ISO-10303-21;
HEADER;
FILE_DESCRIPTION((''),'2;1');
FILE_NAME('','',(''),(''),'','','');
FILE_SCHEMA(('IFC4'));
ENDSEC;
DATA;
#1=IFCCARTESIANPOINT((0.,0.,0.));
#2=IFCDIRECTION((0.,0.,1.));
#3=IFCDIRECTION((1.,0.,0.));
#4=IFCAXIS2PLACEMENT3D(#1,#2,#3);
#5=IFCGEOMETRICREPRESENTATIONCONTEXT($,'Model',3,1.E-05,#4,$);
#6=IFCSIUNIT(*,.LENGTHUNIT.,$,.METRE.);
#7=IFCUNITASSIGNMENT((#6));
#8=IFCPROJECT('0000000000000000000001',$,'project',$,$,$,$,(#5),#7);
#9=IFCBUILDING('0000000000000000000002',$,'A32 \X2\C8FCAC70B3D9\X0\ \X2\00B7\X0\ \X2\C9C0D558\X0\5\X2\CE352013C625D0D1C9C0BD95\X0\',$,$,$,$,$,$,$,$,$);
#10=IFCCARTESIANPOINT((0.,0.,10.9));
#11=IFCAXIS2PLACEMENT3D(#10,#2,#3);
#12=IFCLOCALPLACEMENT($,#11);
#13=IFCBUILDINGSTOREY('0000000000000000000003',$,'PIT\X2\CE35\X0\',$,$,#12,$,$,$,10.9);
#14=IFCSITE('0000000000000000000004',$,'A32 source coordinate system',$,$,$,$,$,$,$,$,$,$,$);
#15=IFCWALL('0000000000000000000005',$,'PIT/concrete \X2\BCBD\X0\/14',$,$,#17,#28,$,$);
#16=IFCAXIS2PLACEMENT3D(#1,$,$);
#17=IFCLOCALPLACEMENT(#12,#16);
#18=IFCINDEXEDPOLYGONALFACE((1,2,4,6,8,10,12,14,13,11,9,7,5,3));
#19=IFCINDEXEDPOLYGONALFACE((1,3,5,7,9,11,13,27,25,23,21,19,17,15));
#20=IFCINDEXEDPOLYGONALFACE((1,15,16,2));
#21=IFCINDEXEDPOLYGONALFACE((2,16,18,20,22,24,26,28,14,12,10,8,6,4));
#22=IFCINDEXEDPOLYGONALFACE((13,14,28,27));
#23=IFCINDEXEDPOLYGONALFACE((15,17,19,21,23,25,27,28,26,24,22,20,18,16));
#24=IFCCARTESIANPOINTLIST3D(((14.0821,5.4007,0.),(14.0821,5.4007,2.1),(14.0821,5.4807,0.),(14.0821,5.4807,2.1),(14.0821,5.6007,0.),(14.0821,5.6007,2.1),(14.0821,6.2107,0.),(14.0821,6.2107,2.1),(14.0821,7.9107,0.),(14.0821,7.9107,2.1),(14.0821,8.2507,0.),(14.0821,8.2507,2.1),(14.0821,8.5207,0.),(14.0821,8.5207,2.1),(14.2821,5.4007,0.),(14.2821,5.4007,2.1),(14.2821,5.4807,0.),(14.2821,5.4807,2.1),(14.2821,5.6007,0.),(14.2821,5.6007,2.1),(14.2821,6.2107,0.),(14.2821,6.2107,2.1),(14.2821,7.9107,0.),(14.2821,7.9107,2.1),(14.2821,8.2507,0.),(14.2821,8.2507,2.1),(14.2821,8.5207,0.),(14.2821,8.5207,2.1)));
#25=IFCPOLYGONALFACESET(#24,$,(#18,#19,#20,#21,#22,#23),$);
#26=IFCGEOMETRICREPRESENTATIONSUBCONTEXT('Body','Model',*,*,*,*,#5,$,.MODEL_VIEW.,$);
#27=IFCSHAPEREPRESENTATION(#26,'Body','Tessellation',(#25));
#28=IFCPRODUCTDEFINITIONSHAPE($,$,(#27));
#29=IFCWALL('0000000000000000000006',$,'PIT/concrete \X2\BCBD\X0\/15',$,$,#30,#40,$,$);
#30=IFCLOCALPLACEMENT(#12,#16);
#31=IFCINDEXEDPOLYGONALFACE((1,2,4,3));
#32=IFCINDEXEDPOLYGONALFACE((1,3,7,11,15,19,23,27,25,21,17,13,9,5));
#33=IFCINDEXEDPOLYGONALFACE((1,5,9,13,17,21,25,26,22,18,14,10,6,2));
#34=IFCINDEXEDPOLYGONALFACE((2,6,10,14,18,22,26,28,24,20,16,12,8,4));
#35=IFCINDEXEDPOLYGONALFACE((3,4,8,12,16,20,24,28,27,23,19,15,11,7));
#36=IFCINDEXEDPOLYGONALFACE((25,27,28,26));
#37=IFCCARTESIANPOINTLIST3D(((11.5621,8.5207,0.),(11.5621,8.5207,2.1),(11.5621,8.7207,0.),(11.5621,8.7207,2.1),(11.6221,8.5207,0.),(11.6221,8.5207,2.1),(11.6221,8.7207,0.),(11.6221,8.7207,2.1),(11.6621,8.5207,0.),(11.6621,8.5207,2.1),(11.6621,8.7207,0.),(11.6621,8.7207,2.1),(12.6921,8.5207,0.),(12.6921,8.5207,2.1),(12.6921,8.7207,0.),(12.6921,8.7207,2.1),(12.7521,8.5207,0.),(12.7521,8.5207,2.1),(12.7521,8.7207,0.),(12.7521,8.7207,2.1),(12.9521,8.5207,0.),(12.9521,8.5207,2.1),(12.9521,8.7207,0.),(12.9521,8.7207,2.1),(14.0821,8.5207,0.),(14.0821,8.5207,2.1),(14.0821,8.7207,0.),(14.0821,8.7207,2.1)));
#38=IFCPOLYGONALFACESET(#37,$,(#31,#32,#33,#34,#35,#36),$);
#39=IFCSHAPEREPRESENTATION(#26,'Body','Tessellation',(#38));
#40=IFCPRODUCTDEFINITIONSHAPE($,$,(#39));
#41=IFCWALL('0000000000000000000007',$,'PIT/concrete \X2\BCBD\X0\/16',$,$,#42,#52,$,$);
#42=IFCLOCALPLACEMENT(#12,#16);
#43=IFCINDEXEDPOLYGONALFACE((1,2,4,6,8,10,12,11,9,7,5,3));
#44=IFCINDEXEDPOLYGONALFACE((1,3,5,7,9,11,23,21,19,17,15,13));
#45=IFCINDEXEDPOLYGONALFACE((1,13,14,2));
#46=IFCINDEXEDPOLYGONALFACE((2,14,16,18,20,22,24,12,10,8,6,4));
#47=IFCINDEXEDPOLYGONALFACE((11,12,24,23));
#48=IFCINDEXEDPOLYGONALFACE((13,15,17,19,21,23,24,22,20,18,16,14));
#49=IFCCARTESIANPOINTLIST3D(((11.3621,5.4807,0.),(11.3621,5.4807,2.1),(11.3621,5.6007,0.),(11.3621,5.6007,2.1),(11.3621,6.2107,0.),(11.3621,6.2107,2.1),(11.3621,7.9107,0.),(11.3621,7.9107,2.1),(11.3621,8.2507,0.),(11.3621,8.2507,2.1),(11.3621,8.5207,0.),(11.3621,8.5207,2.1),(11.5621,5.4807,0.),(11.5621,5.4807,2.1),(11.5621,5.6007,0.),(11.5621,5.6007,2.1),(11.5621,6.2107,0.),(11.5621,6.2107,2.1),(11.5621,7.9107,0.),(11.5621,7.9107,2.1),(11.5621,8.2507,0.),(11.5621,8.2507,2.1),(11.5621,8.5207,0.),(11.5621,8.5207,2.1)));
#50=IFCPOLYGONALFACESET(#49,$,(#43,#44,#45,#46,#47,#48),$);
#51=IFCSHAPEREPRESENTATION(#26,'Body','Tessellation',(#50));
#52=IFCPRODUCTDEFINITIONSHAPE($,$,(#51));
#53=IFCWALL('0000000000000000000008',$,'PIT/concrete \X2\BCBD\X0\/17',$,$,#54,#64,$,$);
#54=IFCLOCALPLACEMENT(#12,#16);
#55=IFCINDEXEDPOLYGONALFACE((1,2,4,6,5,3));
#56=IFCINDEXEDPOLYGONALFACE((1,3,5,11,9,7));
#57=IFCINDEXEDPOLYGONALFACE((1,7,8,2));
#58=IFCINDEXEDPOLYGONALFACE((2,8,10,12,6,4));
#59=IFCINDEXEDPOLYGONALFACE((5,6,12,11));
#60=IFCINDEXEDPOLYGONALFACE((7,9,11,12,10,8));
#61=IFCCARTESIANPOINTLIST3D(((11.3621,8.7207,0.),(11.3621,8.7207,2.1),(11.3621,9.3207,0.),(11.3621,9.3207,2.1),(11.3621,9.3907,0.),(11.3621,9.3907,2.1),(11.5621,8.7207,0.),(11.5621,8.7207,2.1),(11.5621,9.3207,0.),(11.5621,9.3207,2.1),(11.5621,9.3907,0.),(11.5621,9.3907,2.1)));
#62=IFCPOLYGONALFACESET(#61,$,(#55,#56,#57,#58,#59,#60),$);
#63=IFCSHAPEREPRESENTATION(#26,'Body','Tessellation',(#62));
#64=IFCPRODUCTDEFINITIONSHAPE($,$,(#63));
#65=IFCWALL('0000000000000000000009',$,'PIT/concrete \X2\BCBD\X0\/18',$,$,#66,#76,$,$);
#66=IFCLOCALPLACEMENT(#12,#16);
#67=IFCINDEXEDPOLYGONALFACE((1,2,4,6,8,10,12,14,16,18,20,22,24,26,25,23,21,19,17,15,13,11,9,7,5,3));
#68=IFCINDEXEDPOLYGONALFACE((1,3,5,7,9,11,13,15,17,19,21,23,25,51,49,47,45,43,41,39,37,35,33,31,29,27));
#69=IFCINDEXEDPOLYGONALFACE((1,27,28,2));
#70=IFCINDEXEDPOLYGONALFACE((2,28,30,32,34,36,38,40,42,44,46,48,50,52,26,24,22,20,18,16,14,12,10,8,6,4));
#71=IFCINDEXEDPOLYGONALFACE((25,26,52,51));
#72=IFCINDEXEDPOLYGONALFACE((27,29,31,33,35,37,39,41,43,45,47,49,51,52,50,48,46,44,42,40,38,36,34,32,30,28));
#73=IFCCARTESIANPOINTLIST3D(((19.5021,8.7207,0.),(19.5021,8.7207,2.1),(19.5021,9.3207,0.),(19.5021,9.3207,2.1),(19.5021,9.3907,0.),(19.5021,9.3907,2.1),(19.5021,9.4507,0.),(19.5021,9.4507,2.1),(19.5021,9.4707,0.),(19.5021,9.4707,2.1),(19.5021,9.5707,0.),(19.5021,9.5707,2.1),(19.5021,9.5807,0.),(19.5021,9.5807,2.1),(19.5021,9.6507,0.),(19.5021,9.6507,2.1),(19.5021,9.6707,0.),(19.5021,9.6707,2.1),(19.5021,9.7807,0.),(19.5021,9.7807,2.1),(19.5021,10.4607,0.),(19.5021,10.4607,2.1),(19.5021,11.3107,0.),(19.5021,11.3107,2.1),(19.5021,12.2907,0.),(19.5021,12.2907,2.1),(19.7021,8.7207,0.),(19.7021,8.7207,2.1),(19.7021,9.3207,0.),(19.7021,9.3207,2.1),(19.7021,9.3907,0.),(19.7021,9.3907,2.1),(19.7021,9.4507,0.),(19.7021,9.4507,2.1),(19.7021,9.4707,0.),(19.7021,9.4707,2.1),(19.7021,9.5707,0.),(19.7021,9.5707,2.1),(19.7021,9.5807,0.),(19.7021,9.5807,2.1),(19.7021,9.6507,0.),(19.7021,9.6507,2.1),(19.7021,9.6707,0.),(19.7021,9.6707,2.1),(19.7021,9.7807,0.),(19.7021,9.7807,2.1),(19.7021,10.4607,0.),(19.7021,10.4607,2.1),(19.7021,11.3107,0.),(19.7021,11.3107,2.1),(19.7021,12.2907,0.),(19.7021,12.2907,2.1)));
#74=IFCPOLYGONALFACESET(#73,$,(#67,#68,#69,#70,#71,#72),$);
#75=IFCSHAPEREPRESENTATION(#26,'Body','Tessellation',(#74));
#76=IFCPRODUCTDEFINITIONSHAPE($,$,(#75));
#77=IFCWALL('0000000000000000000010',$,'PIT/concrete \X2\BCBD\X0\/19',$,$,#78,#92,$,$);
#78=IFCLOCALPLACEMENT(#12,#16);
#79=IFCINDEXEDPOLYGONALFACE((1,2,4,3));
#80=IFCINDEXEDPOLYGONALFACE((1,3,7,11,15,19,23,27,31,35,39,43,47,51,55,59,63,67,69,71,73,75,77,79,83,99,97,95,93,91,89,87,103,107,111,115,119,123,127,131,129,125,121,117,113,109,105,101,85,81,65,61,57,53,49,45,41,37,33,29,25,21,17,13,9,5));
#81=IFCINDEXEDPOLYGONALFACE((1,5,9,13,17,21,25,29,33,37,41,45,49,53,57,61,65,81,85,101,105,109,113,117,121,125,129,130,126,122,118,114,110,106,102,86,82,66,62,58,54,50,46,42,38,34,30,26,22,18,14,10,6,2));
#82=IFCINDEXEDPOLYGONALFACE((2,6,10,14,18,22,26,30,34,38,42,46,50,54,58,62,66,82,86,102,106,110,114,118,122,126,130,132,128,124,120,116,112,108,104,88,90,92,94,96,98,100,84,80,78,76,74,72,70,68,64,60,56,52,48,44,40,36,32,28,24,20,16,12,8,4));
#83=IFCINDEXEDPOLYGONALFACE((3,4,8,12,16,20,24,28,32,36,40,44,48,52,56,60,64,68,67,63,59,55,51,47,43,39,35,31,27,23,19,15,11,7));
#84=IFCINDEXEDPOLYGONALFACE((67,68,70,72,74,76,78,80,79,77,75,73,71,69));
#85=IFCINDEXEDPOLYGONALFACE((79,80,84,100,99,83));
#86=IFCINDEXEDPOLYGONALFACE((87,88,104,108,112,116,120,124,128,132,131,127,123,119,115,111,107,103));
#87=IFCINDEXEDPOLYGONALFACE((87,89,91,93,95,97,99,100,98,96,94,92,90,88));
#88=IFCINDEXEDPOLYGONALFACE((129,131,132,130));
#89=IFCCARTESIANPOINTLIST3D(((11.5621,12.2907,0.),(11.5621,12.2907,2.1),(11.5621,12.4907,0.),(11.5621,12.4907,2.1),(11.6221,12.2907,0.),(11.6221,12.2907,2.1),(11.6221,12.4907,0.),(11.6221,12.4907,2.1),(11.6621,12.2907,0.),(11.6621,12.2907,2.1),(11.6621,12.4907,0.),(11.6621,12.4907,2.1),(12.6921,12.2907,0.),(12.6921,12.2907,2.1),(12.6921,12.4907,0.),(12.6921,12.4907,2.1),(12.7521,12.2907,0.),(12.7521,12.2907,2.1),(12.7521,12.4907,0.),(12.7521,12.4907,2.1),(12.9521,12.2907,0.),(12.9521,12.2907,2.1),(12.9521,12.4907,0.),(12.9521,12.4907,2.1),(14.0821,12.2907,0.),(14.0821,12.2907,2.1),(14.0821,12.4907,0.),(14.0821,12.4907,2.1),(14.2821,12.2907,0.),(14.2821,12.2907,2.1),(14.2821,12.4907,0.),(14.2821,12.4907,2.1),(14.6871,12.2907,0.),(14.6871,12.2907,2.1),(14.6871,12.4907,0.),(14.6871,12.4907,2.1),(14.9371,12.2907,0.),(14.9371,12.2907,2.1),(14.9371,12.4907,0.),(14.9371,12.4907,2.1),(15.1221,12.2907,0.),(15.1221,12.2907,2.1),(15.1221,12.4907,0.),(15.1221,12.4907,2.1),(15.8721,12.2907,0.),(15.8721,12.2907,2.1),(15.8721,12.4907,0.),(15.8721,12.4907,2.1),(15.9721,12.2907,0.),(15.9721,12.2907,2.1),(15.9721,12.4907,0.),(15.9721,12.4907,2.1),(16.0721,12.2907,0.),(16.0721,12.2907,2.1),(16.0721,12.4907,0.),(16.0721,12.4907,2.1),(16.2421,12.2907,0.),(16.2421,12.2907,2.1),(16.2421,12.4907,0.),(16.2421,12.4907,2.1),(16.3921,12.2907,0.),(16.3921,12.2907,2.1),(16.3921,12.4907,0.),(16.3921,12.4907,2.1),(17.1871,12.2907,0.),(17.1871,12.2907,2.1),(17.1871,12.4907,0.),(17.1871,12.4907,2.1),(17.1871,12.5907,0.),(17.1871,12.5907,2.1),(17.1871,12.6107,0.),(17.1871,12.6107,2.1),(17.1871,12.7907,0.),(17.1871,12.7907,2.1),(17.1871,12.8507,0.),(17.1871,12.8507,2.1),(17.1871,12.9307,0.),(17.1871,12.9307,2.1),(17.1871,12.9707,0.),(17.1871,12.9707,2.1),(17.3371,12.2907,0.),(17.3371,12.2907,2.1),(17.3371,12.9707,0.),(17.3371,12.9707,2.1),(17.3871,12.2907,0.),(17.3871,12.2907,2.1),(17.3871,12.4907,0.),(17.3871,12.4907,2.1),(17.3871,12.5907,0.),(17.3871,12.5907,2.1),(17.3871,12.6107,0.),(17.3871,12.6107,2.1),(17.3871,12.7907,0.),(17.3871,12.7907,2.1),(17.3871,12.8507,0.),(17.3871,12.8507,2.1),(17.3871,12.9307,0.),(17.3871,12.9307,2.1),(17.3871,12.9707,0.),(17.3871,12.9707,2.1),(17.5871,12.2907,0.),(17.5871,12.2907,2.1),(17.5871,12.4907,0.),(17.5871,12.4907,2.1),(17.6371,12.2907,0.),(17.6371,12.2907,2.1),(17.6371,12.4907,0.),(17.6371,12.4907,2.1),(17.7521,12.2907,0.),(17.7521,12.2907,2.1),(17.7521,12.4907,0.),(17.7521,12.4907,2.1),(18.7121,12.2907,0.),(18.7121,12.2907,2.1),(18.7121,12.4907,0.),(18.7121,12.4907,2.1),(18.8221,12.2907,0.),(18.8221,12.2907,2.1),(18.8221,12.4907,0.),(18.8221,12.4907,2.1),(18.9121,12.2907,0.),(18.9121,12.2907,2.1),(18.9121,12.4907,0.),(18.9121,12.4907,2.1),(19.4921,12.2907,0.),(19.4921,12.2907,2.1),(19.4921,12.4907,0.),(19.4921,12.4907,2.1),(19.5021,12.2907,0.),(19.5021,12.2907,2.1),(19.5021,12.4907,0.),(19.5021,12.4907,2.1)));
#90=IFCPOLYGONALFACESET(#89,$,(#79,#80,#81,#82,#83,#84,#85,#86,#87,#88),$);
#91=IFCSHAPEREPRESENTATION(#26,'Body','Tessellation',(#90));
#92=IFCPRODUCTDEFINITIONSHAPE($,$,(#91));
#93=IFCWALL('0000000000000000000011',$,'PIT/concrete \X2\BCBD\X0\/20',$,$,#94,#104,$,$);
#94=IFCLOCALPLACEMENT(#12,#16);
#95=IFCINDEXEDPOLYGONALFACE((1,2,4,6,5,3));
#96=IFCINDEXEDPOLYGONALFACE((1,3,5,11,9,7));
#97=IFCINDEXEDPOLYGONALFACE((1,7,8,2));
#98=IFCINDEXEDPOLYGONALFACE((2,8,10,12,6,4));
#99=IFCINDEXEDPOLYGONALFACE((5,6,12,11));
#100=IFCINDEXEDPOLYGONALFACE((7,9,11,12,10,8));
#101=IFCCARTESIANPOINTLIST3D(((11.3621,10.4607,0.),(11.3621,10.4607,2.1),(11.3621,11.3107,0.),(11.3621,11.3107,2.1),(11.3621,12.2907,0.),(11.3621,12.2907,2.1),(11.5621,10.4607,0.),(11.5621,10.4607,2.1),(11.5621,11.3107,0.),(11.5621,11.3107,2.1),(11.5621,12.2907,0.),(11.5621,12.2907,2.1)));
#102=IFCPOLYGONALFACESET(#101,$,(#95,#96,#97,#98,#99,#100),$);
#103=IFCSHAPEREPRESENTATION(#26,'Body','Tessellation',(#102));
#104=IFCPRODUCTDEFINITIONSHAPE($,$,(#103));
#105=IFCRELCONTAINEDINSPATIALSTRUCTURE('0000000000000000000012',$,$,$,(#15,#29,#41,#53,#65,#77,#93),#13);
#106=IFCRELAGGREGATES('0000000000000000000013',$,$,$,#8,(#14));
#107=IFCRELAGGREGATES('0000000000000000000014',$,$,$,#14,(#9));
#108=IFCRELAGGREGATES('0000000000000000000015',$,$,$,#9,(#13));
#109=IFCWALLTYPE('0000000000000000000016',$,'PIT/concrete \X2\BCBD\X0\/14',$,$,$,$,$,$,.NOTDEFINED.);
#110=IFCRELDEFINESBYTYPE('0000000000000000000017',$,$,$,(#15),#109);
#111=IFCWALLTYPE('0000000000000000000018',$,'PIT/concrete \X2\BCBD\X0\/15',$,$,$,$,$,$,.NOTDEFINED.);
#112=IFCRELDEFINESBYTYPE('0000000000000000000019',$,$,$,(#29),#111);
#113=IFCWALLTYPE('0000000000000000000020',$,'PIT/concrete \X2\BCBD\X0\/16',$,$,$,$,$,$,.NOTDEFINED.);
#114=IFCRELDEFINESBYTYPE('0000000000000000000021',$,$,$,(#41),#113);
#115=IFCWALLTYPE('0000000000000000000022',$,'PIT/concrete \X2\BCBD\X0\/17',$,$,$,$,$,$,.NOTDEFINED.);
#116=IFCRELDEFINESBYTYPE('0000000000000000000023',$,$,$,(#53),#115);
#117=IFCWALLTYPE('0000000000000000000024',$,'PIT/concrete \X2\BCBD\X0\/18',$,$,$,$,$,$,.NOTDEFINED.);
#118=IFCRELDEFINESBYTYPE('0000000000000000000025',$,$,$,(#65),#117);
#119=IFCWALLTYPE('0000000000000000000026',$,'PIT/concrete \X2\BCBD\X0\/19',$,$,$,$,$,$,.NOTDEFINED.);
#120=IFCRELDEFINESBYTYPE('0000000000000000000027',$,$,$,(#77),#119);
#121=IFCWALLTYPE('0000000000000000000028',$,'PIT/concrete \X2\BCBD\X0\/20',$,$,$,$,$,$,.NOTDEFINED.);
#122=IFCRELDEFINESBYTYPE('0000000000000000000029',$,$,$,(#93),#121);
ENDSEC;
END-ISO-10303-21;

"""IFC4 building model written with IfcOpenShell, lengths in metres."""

from ifc_helpers import new_model, si_unit, frame, origin, origin_with_axes, place, context, subcontext, project, spatial, polyline, outline, extrude, source, transform, mapped, type_object, type_shapes, element, save


model = new_model("IFC4")

# Units and contexts
model_context = context("Model", 3, precision=1e-05, world=origin_with_axes())
body_context = subcontext(model_context, "Body", "Model", "MODEL_VIEW")
ifc_project = project(units=[si_unit("LENGTHUNIT", "METRE")], contexts=[model_context])

# Site, building, storey
site = spatial("IfcSite", under=ifc_project, Name="A32 source coordinate system")
building = spatial("IfcBuilding", under=site, Name="A32 주거동 · 지하5층–옥탑지붕")
storey_placement = place(None, frame((0.0, 0.0, 10.9), z_axis=(0.0, 0.0, 1.0), x_axis=(1.0, 0.0, 0.0)))
storey = spatial("IfcBuildingStorey", under=building, at=storey_placement, Name="PIT층", Elevation=10.9)

# Walls
wall_type_1 = type_object("IfcWallType", Name="PIT/concrete 벽/14", PredefinedType="NOTDEFINED")
shared_shape_1 = source(origin(), body_context, "Body", "SweptSolid", [
    extrude(outline(polyline([(14.2821, 6.2107), (14.2821, 5.6007), (14.2821, 5.4807), (14.2821, 5.4007), (14.0821, 5.4007), (14.0821, 5.4807), (14.0821, 5.6007), (14.0821, 6.2107), (14.0821, 7.9107), (14.0821, 8.2507), (14.0821, 8.5207), (14.2821, 8.5207), (14.2821, 8.2507), (14.2821, 7.9107), (14.2821, 6.2107)])), origin(), (0.0, 0.0, 1.0), 2.1),
])
type_shapes(wall_type_1, [shared_shape_1])
wall_1_placement = place(storey_placement, origin_with_axes())
element("IfcWall", 1, at=wall_1_placement, inside=storey, type_object=wall_type_1, Name="PIT/concrete 벽/14", context=body_context, shape_type="MappedRepresentation", body=[
    mapped(shared_shape_1, transform((0.0, 0.0, 0.0), scale=1.0)),
])
wall_type_2 = type_object("IfcWallType", Name="PIT/concrete 벽/15", PredefinedType="NOTDEFINED")
shared_shape_2 = source(origin(), body_context, "Body", "SweptSolid", [
    extrude(outline(polyline([(12.6921, 8.5207), (11.6621, 8.5207), (11.6221, 8.5207), (11.5621, 8.5207), (11.5621, 8.7207), (11.6221, 8.7207), (11.6621, 8.7207), (12.6921, 8.7207), (12.7521, 8.7207), (12.9521, 8.7207), (14.0821, 8.7207), (14.0821, 8.5207), (12.9521, 8.5207), (12.7521, 8.5207), (12.6921, 8.5207)])), origin(), (0.0, 0.0, 1.0), 2.1),
])
type_shapes(wall_type_2, [shared_shape_2])
wall_2_placement = place(storey_placement, origin_with_axes())
element("IfcWall", 2, at=wall_2_placement, inside=storey, type_object=wall_type_2, Name="PIT/concrete 벽/15", context=body_context, shape_type="MappedRepresentation", body=[
    mapped(shared_shape_2, transform((0.0, 0.0, 0.0), scale=1.0)),
])
wall_type_3 = type_object("IfcWallType", Name="PIT/concrete 벽/16", PredefinedType="NOTDEFINED")
shared_shape_3 = source(origin(), body_context, "Body", "SweptSolid", [
    extrude(outline(polyline([(11.5621, 6.2107), (11.5621, 5.6007), (11.5621, 5.4807), (11.3621, 5.4807), (11.3621, 5.6007), (11.3621, 6.2107), (11.3621, 7.9107), (11.3621, 8.2507), (11.3621, 8.5207), (11.5621, 8.5207), (11.5621, 8.2507), (11.5621, 7.9107), (11.5621, 6.2107)])), origin(), (0.0, 0.0, 1.0), 2.1),
])
type_shapes(wall_type_3, [shared_shape_3])
wall_3_placement = place(storey_placement, origin_with_axes())
element("IfcWall", 3, at=wall_3_placement, inside=storey, type_object=wall_type_3, Name="PIT/concrete 벽/16", context=body_context, shape_type="MappedRepresentation", body=[
    mapped(shared_shape_3, transform((0.0, 0.0, 0.0), scale=1.0)),
])
wall_type_4 = type_object("IfcWallType", Name="PIT/concrete 벽/17", PredefinedType="NOTDEFINED")
shared_shape_4 = source(origin(), body_context, "Body", "SweptSolid", [
    extrude(outline(polyline([(11.3621, 9.3907), (11.5621, 9.3907), (11.5621, 9.3207), (11.5621, 8.7207), (11.3621, 8.7207), (11.3621, 9.3207), (11.3621, 9.3907)])), origin(), (0.0, 0.0, 1.0), 2.1),
])
type_shapes(wall_type_4, [shared_shape_4])
wall_4_placement = place(storey_placement, origin_with_axes())
element("IfcWall", 4, at=wall_4_placement, inside=storey, type_object=wall_type_4, Name="PIT/concrete 벽/17", context=body_context, shape_type="MappedRepresentation", body=[
    mapped(shared_shape_4, transform((0.0, 0.0, 0.0), scale=1.0)),
])
wall_type_5 = type_object("IfcWallType", Name="PIT/concrete 벽/18", PredefinedType="NOTDEFINED")
shared_shape_5 = source(origin(), body_context, "Body", "SweptSolid", [
    extrude(outline(polyline([(19.5021, 9.4507), (19.5021, 9.4707), (19.5021, 9.5707), (19.5021, 9.5807), (19.5021, 9.6507), (19.5021, 9.6707), (19.5021, 9.7807), (19.5021, 10.4607), (19.5021, 11.3107), (19.5021, 12.2907), (19.7021, 12.2907), (19.7021, 11.3107), (19.7021, 10.4607), (19.7021, 9.7807), (19.7021, 9.6707), (19.7021, 9.6507), (19.7021, 9.5807), (19.7021, 9.5707), (19.7021, 9.4707), (19.7021, 9.4507), (19.7021, 9.3907), (19.7021, 9.3207), (19.7021, 8.7207), (19.5021, 8.7207), (19.5021, 9.3207), (19.5021, 9.3907), (19.5021, 9.4507)])), origin(), (0.0, 0.0, 1.0), 2.1),
])
type_shapes(wall_type_5, [shared_shape_5])
wall_5_placement = place(storey_placement, origin_with_axes())
element("IfcWall", 5, at=wall_5_placement, inside=storey, type_object=wall_type_5, Name="PIT/concrete 벽/18", context=body_context, shape_type="MappedRepresentation", body=[
    mapped(shared_shape_5, transform((0.0, 0.0, 0.0), scale=1.0)),
])
wall_type_6 = type_object("IfcWallType", Name="PIT/concrete 벽/19", PredefinedType="NOTDEFINED")
shared_shape_6 = source(origin(), body_context, "Body", "SweptSolid", [
    extrude(outline(polyline([(18.8221, 12.2907), (18.7121, 12.2907), (17.7521, 12.2907), (17.6371, 12.2907), (17.5871, 12.2907), (17.3871, 12.2907), (17.3371, 12.2907), (17.1871, 12.2907), (16.3921, 12.2907), (16.2421, 12.2907), (16.0721, 12.2907), (15.9721, 12.2907), (15.8721, 12.2907), (15.1221, 12.2907), (14.9371, 12.2907), (14.6871, 12.2907), (14.2821, 12.2907), (14.0821, 12.2907), (12.9521, 12.2907), (12.7521, 12.2907), (12.6921, 12.2907), (11.6621, 12.2907), (11.6221, 12.2907), (11.5621, 12.2907), (11.5621, 12.4907), (11.6221, 12.4907), (11.6621, 12.4907), (12.6921, 12.4907), (12.7521, 12.4907), (12.9521, 12.4907), (14.0821, 12.4907), (14.2821, 12.4907), (14.6871, 12.4907), (14.9371, 12.4907), (15.1221, 12.4907), (15.8721, 12.4907), (15.9721, 12.4907), (16.0721, 12.4907), (16.2421, 12.4907), (16.3921, 12.4907), (17.1871, 12.4907), (17.1871, 12.5907), (17.1871, 12.6107), (17.1871, 12.7907), (17.1871, 12.8507), (17.1871, 12.9307), (17.1871, 12.9707), (17.3371, 12.9707), (17.3871, 12.9707), (17.3871, 12.9307), (17.3871, 12.8507), (17.3871, 12.7907), (17.3871, 12.6107), (17.3871, 12.5907), (17.3871, 12.4907), (17.5871, 12.4907), (17.6371, 12.4907), (17.7521, 12.4907), (18.7121, 12.4907), (18.8221, 12.4907), (18.9121, 12.4907), (19.4921, 12.4907), (19.5021, 12.4907), (19.5021, 12.2907), (19.4921, 12.2907), (18.9121, 12.2907), (18.8221, 12.2907)])), origin(), (0.0, 0.0, 1.0), 2.1),
])
type_shapes(wall_type_6, [shared_shape_6])
wall_6_placement = place(storey_placement, origin_with_axes())
element("IfcWall", 6, at=wall_6_placement, inside=storey, type_object=wall_type_6, Name="PIT/concrete 벽/19", context=body_context, shape_type="MappedRepresentation", body=[
    mapped(shared_shape_6, transform((0.0, 0.0, 0.0), scale=1.0)),
])
wall_type_7 = type_object("IfcWallType", Name="PIT/concrete 벽/20", PredefinedType="NOTDEFINED")
shared_shape_7 = source(origin(), body_context, "Body", "SweptSolid", [
    extrude(outline(polyline([(11.3621, 10.4607), (11.3621, 11.3107), (11.3621, 12.2907), (11.5621, 12.2907), (11.5621, 11.3107), (11.5621, 10.4607), (11.3621, 10.4607)])), origin(), (0.0, 0.0, 1.0), 2.1),
])
type_shapes(wall_type_7, [shared_shape_7])
wall_7_placement = place(storey_placement, origin_with_axes())
element("IfcWall", 7, at=wall_7_placement, inside=storey, type_object=wall_type_7, Name="PIT/concrete 벽/20", context=body_context, shape_type="MappedRepresentation", body=[
    mapped(shared_shape_7, transform((0.0, 0.0, 0.0), scale=1.0)),
])

save(model, "model.ifc")
